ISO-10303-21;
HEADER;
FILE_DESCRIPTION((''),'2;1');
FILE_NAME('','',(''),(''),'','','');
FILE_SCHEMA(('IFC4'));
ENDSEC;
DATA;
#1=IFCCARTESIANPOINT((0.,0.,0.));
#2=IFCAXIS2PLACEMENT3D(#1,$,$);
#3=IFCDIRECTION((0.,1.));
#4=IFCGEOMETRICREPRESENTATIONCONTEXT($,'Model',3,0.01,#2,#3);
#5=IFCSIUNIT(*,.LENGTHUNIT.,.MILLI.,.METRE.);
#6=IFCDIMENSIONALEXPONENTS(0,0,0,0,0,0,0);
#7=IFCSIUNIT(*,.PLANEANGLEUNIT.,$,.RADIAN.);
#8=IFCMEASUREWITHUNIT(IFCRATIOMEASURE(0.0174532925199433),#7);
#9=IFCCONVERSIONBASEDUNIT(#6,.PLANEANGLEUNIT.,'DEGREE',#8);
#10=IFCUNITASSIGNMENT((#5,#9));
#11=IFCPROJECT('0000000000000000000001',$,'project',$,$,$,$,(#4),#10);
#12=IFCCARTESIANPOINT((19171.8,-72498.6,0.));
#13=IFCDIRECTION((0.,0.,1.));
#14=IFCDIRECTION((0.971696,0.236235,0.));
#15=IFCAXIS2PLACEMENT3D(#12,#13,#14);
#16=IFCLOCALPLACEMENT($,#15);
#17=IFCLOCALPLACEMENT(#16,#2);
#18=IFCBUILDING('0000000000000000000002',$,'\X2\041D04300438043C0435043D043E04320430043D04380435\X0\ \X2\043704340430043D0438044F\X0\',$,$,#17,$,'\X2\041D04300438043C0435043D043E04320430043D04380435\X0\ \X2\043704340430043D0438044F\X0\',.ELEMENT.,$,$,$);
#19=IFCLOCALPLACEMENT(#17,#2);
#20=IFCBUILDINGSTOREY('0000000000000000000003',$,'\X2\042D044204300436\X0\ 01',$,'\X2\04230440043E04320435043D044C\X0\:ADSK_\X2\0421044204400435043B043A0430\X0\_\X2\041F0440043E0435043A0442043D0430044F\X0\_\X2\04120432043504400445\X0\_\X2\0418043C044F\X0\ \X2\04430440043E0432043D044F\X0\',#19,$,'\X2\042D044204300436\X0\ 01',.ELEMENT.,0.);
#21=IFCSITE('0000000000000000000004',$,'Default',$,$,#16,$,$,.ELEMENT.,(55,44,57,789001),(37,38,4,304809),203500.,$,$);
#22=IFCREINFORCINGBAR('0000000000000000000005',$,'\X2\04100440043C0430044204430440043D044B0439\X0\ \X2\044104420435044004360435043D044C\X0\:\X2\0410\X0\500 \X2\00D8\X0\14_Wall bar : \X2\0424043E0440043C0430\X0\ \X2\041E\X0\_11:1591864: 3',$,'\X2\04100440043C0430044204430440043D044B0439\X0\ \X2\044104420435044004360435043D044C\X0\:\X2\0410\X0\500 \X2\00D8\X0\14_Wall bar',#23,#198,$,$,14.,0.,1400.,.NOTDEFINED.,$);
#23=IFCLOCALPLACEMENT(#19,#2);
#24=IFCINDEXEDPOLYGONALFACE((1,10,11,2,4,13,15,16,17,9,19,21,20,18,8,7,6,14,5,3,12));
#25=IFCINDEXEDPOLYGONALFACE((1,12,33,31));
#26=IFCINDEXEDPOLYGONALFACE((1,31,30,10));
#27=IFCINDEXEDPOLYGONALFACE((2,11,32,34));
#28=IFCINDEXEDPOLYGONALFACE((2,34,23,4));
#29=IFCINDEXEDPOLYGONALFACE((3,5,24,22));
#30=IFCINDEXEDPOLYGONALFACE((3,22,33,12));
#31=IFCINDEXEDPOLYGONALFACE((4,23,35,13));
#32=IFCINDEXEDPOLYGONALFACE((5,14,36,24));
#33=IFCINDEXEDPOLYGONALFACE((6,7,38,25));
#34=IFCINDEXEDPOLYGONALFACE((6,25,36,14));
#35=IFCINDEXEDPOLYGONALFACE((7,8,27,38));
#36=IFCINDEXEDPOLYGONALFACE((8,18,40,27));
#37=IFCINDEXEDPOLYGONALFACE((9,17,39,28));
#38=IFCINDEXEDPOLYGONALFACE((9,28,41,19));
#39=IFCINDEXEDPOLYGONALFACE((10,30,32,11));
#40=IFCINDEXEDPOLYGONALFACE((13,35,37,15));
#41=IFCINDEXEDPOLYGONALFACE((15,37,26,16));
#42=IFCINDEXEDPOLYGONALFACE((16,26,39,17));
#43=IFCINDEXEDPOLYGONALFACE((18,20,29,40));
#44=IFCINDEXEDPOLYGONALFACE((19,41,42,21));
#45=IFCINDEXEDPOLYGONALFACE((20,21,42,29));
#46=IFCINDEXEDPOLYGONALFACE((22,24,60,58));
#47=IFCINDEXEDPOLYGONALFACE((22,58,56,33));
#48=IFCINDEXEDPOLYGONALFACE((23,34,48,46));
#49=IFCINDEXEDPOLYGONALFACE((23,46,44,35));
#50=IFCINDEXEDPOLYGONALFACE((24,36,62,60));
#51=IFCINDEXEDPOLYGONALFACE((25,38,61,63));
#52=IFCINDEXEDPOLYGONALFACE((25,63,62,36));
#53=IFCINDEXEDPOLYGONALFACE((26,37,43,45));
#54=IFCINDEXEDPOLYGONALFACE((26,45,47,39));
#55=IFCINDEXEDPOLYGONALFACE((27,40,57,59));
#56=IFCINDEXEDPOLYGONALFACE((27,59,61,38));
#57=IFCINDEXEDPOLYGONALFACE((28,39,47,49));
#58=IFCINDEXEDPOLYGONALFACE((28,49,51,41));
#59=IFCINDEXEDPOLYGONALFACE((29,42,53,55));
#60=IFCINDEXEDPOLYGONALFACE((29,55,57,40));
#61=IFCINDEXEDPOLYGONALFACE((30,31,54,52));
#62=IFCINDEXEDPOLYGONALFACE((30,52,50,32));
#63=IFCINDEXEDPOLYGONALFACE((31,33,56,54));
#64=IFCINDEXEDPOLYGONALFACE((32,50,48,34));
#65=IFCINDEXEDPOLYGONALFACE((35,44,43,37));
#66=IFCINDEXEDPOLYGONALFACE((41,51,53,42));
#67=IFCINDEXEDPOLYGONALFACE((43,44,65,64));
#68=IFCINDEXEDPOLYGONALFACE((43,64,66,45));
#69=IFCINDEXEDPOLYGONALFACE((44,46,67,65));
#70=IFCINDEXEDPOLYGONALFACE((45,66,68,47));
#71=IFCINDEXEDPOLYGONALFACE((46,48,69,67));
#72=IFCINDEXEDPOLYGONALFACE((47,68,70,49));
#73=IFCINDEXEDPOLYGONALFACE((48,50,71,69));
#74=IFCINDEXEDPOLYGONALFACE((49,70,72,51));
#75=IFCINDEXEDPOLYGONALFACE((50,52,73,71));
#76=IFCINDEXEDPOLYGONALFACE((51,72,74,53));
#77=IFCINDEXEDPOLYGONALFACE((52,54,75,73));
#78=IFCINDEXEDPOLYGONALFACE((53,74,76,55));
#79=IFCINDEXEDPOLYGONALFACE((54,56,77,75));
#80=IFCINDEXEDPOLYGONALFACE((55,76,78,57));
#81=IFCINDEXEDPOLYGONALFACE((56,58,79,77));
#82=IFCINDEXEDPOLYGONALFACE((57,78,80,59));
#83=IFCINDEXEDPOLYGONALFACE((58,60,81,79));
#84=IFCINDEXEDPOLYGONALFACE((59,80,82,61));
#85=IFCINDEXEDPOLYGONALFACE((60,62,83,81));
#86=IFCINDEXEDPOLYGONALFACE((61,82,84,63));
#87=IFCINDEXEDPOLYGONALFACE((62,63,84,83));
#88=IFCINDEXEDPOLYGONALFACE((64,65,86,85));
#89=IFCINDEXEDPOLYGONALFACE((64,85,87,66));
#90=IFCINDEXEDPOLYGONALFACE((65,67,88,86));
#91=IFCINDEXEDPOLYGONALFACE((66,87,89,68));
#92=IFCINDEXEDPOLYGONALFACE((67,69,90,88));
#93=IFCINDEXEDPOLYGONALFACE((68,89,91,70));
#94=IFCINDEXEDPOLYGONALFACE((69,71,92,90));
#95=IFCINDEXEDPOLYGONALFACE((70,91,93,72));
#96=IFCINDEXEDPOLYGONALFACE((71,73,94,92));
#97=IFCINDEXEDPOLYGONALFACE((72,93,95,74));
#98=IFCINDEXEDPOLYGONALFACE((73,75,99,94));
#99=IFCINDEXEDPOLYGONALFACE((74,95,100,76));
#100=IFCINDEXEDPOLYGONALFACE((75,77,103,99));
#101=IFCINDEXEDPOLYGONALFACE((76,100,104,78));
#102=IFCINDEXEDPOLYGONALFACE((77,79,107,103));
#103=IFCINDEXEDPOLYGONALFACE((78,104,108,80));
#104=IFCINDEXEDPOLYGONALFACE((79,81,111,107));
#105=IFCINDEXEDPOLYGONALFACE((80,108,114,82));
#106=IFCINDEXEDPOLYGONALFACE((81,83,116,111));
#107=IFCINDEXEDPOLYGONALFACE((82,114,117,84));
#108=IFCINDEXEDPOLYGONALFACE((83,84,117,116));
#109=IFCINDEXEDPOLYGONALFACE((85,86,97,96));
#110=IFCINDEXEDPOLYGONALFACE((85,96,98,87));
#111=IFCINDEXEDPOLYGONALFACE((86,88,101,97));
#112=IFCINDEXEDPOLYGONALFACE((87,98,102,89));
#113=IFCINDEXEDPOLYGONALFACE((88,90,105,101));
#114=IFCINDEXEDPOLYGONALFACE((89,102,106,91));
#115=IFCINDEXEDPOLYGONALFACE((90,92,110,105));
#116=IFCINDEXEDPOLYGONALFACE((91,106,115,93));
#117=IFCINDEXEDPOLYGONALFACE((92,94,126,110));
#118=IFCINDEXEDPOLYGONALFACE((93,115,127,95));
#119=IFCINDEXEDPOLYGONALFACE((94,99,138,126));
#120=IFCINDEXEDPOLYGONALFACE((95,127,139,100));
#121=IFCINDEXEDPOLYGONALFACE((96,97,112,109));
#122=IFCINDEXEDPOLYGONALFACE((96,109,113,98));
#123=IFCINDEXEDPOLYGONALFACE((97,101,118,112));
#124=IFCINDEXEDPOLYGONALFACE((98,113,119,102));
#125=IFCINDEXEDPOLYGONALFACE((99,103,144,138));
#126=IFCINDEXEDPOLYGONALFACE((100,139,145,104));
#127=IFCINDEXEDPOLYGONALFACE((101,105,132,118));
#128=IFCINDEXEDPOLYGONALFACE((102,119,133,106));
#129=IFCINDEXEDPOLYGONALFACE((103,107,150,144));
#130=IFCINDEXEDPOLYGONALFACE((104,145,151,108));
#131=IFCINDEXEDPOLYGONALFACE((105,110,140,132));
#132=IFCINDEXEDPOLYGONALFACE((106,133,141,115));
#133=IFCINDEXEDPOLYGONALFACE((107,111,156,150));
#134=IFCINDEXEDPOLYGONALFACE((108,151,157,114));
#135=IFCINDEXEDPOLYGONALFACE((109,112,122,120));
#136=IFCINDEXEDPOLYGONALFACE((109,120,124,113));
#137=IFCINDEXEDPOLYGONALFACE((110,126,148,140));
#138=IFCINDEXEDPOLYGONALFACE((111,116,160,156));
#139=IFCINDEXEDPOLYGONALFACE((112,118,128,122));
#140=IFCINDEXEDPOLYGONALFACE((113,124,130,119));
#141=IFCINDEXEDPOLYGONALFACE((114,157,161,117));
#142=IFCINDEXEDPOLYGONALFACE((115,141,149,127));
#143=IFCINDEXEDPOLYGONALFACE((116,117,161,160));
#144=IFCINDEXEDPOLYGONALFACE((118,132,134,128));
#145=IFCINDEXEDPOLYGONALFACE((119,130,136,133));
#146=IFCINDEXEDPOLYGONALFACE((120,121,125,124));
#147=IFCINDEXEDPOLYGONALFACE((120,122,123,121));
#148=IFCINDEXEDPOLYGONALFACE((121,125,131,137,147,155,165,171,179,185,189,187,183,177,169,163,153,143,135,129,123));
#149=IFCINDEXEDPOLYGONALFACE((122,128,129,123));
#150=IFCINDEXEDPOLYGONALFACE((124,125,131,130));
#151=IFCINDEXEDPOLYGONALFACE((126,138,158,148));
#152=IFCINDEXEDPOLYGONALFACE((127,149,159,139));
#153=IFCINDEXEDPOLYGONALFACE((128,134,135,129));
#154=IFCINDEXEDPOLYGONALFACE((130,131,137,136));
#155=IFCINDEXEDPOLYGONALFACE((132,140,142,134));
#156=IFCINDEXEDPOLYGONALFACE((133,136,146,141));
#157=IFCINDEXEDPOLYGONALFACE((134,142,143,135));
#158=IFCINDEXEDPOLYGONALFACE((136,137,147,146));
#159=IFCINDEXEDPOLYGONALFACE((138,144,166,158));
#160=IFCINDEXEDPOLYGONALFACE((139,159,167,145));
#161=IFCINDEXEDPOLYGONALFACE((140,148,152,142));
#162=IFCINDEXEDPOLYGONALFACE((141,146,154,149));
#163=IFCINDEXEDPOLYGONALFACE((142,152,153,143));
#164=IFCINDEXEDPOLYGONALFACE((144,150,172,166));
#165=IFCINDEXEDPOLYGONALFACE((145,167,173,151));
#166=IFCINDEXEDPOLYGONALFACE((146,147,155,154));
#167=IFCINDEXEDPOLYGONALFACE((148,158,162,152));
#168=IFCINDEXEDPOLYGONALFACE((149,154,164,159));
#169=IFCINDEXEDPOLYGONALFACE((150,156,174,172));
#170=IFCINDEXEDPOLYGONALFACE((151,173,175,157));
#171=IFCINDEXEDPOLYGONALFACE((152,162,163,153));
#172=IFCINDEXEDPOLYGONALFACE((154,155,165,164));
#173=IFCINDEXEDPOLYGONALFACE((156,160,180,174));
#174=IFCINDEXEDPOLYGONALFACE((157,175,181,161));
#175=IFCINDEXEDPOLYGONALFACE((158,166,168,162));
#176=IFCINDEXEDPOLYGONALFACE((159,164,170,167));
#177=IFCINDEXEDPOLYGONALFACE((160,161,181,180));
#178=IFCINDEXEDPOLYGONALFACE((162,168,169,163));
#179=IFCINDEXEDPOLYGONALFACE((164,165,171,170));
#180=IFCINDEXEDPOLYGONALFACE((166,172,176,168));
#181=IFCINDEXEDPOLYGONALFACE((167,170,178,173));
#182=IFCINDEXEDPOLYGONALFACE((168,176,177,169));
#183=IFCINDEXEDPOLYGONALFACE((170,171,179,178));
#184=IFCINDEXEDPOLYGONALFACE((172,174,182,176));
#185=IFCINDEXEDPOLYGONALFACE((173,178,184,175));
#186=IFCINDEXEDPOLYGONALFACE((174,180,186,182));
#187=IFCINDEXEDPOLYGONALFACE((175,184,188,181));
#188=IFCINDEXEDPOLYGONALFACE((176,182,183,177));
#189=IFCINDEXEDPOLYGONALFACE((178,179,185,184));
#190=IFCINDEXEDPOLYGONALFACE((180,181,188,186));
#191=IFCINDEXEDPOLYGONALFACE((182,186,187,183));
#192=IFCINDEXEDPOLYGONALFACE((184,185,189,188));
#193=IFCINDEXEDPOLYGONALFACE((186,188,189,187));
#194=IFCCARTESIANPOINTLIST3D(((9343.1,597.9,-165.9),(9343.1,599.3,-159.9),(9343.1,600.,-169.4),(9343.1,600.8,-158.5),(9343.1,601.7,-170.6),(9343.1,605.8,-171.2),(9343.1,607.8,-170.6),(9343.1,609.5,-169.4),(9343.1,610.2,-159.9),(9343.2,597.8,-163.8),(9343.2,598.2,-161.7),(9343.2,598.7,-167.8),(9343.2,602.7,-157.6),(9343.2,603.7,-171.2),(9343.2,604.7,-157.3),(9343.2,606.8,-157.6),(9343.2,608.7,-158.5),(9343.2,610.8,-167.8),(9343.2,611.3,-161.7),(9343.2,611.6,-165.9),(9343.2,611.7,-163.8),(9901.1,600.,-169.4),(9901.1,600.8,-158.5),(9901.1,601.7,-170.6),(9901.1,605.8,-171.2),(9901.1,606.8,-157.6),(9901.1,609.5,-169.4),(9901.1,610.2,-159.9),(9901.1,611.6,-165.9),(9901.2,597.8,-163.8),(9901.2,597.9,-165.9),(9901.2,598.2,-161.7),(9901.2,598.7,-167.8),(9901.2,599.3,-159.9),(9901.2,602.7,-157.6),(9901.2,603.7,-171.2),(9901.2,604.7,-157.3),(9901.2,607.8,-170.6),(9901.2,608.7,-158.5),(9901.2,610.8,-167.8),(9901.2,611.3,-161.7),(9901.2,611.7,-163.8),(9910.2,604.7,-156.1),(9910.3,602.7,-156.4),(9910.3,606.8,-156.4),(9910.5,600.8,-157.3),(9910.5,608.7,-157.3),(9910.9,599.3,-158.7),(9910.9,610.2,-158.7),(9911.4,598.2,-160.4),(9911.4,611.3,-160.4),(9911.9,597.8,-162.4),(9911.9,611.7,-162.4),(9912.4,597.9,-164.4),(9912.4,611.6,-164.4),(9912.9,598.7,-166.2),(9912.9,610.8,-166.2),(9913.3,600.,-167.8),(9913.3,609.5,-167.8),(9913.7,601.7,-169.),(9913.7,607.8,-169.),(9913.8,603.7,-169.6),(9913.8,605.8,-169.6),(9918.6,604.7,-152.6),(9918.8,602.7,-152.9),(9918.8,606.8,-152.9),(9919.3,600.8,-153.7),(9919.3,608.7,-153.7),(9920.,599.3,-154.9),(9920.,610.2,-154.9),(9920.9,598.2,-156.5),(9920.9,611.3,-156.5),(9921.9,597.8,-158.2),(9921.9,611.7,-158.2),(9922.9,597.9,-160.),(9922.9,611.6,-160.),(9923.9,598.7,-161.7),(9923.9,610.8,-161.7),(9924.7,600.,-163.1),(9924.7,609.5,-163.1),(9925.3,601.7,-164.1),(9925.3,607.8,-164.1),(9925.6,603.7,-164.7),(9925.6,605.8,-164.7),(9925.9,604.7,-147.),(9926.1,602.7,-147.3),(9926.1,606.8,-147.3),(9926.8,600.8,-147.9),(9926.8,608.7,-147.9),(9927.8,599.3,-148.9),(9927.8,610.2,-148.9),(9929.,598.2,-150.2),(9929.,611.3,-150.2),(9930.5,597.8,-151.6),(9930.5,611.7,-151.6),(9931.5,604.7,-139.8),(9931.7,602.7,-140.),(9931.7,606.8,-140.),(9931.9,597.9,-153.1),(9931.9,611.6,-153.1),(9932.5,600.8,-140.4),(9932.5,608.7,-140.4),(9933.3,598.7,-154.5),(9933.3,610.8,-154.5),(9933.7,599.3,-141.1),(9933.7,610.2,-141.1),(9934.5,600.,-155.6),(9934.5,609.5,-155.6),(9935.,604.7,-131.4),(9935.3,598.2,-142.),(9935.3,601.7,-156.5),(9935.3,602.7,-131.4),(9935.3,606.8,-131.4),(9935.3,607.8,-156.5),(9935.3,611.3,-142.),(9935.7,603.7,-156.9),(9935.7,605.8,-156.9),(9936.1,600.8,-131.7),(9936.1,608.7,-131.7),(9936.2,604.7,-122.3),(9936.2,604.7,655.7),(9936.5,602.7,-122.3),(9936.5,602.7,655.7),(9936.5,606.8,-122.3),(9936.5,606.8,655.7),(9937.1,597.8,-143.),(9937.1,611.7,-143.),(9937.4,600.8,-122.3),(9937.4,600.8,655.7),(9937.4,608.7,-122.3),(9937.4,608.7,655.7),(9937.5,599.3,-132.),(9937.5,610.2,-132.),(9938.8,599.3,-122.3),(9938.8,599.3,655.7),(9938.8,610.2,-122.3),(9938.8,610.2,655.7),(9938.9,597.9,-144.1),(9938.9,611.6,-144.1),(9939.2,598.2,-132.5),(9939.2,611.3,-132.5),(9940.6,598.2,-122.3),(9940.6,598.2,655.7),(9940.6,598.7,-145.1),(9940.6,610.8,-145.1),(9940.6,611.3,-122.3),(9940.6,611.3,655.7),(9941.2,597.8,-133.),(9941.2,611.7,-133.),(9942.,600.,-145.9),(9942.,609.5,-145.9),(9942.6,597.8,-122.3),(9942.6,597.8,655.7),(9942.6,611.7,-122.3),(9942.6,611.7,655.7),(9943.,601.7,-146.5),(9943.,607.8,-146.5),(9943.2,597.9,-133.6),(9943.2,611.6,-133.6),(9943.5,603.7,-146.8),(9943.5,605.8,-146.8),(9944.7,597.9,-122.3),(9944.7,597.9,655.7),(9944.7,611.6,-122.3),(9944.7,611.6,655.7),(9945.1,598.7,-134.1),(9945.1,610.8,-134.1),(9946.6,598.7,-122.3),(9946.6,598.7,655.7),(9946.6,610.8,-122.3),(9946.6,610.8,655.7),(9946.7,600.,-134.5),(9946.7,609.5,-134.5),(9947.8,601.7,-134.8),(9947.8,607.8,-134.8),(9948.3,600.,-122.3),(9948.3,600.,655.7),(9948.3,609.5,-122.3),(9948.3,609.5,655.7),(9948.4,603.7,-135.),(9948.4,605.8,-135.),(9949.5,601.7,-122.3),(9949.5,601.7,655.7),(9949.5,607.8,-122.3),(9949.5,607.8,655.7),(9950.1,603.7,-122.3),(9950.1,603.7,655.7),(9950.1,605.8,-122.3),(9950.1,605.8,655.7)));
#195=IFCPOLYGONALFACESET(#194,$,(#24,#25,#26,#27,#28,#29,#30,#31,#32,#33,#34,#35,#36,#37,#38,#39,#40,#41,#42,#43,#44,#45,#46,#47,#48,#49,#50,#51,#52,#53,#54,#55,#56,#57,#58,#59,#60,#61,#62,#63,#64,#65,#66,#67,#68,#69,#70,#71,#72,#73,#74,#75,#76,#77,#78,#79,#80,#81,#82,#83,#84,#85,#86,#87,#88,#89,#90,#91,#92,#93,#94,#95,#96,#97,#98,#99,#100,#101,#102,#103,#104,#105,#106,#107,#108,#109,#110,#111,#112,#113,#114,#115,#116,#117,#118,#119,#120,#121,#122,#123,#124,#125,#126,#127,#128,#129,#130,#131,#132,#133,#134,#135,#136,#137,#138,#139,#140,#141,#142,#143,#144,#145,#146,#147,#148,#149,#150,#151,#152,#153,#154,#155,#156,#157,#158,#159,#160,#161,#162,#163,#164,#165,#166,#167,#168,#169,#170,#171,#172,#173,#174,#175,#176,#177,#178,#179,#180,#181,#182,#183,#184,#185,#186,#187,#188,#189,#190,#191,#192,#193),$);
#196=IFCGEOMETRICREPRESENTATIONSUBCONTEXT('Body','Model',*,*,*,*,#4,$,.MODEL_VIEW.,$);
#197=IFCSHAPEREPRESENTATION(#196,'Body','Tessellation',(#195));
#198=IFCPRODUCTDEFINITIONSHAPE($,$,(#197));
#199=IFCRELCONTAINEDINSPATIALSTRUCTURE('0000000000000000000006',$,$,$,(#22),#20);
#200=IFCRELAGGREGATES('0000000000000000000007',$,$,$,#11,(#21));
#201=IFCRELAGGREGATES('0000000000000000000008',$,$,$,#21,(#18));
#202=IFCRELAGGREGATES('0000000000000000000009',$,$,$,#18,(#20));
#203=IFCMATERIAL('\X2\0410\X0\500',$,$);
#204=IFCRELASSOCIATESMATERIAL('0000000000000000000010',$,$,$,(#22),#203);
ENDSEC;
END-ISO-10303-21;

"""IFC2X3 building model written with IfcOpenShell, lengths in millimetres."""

from ifc_helpers import new_model, entity, si_unit, converted_unit, direction, frame, origin, place, context, subcontext, project, spatial, material, element, save


model = new_model("IFC2X3")

# Units and contexts
model_context = context("Model", 3, precision=0.01, world=origin(), true_north=direction((0.0, 1.0)))
body_context = subcontext(model_context, "Body", "Model", "MODEL_VIEW")
ifc_project = project(units=[si_unit("LENGTHUNIT", "METRE", prefix="MILLI"), converted_unit("PLANEANGLEUNIT", "DEGREE", entity("IfcRatioMeasure", 0.0174532925199433), si_unit("PLANEANGLEUNIT", "RADIAN"), dimensions=[0, 0, 0, 0, 0, 0, 0])], contexts=[model_context])

# Site, building, storey
site_placement = place(None, frame((19171.8, -72498.6, 0.0), z_axis=(0.0, 0.0, 1.0), x_axis=(0.971696, 0.236235, 0.0)))
site = spatial("IfcSite", under=ifc_project, at=site_placement, Name="Default", CompositionType="ELEMENT", RefLatitude=(55, 44, 57, 789001), RefLongitude=(37, 38, 4, 304809), RefElevation=203500.0)
building_placement = place(site_placement, origin())
building = spatial("IfcBuilding", under=site, at=building_placement, Name="Наименование здания", LongName="Наименование здания", CompositionType="ELEMENT")
storey_placement = place(building_placement, origin())
storey = spatial("IfcBuildingStorey", under=building, at=storey_placement, Name="Этаж 01", ObjectType="Уровень:ADSK_Стрелка_Проектная_Вверх_Имя уровня", LongName="Этаж 01", CompositionType="ELEMENT", Elevation=0.0)

# Reinforcing bar
ifc_material = material(Name="А500")
placement = place(storey_placement, origin())
element("IfcReinforcingBar", 1, at=placement, inside=storey, material=ifc_material, Name="Арматурный стержень:А500 Ø14_Wall bar : Форма О_11:1591864: 3", ObjectType="Арматурный стержень:А500 Ø14_Wall bar", BarLength=1400.0, BarRole="NOTDEFINED", CrossSectionArea=0.0, NominalDiameter=14.0, context=body_context, shape_type="AdvancedSweptSolid", body=[
    entity("IfcSweptDiskSolid", entity("IfcCompositeCurve", [entity("IfcCompositeCurveSegment", "CONTINUOUS", True, entity("IfcPolyline", [entity("IfcCartesianPoint", [9943.1, 604.7, 655.7]), entity("IfcCartesianPoint", [9943.1, 604.7, -122.3])])), entity("IfcCompositeCurveSegment", "CONTINUOUS", True, entity("IfcTrimmedCurve", entity("IfcCircle", entity("IfcAxis2Placement3D", entity("IfcCartesianPoint", [9901.1, 604.7, -122.3]), entity("IfcDirection", [0.0, 1.0, 0.0]), entity("IfcDirection", [0.0, 0.0, -1.0])), 42.0), [entity("IfcParameterValue", 270.0)], [entity("IfcParameterValue", 360.0)], True, "PARAMETER")), entity("IfcCompositeCurveSegment", "CONTINUOUS", True, entity("IfcPolyline", [entity("IfcCartesianPoint", [9901.1, 604.7, -164.3]), entity("IfcCartesianPoint", [9343.1, 604.7, -164.3])]))], False), 7.0, None, 0.0, 92.0),
])

save(model, "model.ifc")
